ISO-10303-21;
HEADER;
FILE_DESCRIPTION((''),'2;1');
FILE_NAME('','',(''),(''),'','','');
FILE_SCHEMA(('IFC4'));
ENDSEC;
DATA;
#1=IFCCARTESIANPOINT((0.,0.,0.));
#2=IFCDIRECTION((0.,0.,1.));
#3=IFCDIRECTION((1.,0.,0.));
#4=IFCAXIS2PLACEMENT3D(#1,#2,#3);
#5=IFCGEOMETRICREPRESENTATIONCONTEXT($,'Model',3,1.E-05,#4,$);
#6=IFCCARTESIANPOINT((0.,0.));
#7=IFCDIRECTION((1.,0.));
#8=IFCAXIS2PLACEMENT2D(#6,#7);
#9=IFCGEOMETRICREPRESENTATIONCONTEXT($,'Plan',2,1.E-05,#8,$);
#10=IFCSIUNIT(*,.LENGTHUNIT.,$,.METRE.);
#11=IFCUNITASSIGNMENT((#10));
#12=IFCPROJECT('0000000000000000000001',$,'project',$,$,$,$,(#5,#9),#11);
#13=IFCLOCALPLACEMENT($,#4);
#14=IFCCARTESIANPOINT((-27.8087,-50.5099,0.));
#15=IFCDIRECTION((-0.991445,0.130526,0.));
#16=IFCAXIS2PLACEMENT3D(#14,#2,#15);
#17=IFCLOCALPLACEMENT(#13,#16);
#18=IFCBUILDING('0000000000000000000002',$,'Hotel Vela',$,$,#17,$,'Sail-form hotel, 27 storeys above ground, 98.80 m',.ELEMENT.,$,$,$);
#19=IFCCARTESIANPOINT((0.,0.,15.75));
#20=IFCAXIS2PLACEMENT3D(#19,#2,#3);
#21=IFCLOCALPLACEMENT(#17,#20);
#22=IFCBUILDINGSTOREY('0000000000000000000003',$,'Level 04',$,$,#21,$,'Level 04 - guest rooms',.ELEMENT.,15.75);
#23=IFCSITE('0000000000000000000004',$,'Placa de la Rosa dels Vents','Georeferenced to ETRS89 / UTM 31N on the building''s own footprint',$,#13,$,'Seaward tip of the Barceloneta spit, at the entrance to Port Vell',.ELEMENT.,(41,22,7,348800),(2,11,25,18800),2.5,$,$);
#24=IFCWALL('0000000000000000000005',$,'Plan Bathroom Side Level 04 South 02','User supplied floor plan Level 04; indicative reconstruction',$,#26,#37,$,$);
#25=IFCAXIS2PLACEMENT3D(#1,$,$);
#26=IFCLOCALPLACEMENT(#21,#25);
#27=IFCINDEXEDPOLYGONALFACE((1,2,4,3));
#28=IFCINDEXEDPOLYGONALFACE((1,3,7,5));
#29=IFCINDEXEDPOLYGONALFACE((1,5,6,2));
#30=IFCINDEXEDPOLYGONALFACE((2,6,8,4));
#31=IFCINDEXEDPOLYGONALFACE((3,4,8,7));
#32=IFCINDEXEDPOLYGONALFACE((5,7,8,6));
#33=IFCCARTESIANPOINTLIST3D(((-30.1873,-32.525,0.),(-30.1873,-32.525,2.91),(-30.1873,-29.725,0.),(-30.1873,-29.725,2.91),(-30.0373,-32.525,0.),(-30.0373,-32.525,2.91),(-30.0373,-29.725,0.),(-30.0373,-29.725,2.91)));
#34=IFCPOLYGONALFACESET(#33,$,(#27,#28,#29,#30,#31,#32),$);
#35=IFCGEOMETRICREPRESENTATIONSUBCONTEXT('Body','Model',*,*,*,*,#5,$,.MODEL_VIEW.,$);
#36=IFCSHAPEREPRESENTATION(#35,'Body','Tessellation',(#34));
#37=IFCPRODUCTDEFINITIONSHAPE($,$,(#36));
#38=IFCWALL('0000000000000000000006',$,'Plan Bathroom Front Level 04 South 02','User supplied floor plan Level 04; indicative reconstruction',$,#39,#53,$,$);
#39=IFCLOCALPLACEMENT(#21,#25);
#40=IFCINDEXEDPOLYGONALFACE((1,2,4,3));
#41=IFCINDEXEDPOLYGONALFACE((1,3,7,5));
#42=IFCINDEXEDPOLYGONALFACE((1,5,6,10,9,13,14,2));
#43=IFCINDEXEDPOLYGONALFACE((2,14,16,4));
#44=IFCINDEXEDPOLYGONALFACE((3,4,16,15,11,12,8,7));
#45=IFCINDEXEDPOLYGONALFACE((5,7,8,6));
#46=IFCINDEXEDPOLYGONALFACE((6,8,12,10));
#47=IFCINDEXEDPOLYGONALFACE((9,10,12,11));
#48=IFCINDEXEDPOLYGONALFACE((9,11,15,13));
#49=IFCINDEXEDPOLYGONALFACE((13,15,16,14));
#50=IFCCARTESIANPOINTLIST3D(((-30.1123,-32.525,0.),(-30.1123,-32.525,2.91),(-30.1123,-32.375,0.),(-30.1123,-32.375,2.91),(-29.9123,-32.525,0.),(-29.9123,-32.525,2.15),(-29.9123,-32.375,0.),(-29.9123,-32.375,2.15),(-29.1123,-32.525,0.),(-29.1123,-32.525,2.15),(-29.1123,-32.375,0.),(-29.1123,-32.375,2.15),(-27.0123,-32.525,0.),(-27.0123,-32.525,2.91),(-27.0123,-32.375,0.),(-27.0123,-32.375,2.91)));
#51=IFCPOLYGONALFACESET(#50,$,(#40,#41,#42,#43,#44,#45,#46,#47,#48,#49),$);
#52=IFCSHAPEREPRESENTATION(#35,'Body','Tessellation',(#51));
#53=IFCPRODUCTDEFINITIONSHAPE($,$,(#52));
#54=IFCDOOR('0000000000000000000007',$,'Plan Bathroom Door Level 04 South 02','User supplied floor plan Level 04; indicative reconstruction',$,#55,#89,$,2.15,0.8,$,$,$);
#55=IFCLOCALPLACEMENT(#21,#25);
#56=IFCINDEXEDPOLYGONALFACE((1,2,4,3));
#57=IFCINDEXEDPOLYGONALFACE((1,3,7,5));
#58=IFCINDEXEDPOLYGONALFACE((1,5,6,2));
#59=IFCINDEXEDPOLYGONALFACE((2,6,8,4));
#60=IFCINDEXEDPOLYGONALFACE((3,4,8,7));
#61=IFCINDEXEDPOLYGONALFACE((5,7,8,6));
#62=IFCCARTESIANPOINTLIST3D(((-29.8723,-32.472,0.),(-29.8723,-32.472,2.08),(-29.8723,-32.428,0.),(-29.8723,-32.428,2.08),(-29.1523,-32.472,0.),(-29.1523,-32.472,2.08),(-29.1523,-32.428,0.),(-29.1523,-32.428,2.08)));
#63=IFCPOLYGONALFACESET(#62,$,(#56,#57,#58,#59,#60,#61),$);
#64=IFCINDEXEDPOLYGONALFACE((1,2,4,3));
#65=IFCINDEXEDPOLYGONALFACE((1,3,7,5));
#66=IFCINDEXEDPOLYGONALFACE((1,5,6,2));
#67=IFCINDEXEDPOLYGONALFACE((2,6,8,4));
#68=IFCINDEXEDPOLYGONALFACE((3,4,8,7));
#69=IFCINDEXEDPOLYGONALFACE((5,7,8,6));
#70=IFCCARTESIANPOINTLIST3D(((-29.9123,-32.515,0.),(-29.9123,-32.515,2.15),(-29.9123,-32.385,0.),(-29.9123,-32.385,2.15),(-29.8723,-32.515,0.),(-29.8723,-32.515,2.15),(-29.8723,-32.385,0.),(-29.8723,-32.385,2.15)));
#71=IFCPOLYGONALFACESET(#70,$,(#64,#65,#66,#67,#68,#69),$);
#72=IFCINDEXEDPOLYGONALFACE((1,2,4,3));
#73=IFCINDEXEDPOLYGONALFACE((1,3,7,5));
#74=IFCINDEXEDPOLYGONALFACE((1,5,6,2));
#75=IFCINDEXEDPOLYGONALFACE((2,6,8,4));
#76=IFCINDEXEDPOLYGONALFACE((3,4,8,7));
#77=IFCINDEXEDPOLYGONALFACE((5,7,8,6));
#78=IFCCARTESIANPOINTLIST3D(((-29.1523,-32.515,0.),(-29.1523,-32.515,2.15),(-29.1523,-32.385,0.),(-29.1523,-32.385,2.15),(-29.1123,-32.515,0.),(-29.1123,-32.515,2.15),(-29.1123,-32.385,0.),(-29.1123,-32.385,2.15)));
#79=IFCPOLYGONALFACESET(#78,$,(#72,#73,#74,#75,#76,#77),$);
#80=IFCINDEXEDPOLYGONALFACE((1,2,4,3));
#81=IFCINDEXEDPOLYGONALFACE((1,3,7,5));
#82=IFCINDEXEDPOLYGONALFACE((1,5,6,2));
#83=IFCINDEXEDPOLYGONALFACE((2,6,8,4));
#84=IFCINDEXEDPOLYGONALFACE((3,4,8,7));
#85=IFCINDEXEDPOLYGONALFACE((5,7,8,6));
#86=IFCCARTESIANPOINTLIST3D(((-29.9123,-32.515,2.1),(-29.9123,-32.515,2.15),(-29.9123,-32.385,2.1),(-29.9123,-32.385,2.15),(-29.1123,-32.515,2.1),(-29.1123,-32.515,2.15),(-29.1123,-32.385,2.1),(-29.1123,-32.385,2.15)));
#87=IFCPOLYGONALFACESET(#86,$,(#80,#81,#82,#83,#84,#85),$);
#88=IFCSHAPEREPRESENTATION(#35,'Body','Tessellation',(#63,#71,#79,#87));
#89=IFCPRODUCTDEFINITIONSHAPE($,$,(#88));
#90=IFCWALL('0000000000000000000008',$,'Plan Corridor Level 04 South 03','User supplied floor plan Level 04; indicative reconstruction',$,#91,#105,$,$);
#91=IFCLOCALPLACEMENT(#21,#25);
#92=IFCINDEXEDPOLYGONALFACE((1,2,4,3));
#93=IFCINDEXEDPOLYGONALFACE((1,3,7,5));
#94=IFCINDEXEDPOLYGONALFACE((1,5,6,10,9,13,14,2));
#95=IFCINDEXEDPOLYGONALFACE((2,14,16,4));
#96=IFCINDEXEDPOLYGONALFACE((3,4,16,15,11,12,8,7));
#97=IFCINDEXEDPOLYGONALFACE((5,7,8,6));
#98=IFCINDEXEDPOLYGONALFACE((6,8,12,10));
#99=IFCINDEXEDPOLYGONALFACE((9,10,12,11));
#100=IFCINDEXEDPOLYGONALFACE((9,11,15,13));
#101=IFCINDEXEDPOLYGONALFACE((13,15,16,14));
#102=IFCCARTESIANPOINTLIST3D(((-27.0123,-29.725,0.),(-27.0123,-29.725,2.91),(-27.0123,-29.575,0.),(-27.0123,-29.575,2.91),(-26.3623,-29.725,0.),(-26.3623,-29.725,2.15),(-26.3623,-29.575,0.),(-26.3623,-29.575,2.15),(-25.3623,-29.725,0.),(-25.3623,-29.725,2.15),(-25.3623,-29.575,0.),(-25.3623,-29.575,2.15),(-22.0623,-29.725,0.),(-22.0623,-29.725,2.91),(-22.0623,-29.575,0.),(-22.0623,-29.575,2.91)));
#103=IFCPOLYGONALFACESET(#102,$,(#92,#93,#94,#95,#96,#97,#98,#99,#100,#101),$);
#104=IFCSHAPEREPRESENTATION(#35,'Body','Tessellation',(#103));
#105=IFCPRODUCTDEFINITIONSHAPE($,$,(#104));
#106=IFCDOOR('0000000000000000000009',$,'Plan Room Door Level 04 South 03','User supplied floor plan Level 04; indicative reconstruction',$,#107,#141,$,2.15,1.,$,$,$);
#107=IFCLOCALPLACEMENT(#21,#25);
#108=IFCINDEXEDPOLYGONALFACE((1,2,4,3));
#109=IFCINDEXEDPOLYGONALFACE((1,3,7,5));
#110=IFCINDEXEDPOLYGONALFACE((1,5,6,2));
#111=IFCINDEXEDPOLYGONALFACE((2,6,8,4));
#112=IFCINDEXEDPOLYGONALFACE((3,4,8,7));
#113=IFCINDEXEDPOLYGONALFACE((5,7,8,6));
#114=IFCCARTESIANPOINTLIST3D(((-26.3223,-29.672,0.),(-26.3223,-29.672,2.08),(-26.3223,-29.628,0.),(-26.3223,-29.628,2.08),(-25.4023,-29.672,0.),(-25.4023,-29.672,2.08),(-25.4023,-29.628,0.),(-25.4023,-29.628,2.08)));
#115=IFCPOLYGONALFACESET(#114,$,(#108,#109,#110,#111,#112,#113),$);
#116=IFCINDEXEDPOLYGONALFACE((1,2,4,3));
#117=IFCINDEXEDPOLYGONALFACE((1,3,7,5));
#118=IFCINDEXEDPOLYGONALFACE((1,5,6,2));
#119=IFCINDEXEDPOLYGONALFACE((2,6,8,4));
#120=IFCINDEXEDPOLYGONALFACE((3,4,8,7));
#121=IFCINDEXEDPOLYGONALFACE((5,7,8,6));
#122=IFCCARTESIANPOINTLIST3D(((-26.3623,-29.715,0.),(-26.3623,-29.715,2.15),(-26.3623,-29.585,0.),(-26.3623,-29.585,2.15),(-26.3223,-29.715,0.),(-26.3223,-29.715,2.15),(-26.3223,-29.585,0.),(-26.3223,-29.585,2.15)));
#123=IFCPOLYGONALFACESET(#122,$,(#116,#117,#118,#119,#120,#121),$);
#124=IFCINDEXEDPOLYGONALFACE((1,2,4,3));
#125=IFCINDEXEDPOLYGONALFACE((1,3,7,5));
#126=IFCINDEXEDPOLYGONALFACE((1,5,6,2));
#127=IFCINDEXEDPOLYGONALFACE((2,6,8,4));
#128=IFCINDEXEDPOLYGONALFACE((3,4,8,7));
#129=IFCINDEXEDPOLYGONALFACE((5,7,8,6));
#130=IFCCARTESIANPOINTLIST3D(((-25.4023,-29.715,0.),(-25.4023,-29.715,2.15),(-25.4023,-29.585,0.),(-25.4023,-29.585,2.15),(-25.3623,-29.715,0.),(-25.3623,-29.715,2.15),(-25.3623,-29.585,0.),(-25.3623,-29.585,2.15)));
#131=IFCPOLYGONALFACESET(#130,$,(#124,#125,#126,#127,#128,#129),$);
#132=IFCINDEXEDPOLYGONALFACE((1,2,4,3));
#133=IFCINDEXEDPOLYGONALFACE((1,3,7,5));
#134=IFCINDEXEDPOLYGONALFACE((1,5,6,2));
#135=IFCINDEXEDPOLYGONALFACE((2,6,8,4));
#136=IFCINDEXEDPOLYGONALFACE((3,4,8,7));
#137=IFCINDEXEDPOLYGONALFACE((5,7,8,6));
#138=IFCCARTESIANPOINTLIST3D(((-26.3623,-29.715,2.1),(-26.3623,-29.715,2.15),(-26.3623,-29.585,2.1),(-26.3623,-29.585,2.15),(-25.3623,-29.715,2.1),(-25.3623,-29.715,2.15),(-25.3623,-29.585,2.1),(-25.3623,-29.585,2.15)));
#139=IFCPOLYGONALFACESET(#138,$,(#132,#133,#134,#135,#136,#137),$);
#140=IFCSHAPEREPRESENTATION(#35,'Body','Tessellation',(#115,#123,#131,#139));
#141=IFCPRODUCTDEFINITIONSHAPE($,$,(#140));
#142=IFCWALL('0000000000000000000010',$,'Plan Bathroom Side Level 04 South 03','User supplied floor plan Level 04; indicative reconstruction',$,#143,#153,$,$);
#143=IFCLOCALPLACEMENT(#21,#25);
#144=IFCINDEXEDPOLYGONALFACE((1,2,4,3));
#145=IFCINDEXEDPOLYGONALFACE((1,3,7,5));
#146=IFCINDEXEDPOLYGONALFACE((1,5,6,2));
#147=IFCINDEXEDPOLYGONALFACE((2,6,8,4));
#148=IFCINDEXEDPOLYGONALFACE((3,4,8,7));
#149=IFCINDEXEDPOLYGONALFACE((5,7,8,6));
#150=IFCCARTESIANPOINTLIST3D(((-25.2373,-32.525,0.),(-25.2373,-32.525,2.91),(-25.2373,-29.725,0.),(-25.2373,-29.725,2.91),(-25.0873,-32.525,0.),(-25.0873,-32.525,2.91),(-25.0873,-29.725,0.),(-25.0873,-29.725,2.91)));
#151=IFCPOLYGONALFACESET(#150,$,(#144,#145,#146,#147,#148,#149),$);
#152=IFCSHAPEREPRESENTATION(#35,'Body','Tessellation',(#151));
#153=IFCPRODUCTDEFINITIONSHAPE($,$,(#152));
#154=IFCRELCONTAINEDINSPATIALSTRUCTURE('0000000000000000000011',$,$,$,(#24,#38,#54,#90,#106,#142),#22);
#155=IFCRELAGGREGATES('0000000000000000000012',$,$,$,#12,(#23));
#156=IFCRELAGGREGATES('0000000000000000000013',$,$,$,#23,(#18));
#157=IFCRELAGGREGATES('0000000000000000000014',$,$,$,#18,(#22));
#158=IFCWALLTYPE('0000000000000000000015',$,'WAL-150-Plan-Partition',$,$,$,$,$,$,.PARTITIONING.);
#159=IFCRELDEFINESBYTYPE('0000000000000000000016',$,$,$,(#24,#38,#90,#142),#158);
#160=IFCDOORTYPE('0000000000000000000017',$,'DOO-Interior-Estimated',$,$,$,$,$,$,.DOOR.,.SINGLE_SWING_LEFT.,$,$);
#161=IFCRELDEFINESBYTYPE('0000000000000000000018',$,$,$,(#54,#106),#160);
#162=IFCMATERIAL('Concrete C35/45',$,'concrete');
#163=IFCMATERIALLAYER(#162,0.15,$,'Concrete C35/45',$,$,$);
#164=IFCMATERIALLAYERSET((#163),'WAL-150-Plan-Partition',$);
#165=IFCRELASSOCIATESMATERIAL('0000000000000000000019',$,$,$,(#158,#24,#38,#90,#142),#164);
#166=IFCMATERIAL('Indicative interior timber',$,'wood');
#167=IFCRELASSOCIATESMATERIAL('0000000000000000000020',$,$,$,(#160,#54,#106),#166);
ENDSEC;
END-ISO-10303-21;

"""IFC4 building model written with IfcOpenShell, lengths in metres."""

from ifc_helpers import new_model, si_unit, frame, origin_with_axes, origin_2d_with_axis, place, context, subcontext, project, spatial, line, indexed_curve, outline, extrude, material, layer, layer_set, layer_usage, type_object, element, fill, save


model = new_model("IFC4")

# Units and contexts
model_context = context("Model", 3, precision=1e-05, world=origin_with_axes())
plan_context = context("Plan", 2, precision=1e-05, world=origin_2d_with_axis())
body_context = subcontext(model_context, "Body", "Model", "MODEL_VIEW")
ifc_project = project(units=[si_unit("LENGTHUNIT", "METRE")], contexts=[model_context, plan_context])

# Site, building, storey
site_placement = place(None, origin_with_axes())
site = spatial("IfcSite", under=ifc_project, at=site_placement, Name="Placa de la Rosa dels Vents", Description="Georeferenced to ETRS89 / UTM 31N on the building's own footprint", LongName="Seaward tip of the Barceloneta spit, at the entrance to Port Vell", CompositionType="ELEMENT", RefLatitude=(41, 22, 7, 348800), RefLongitude=(2, 11, 25, 18800), RefElevation=2.5)
building_placement = place(site_placement, frame((-27.8087, -50.5099, 0.0), z_axis=(0.0, 0.0, 1.0), x_axis=(-0.991445, 0.130526, 0.0)))
building = spatial("IfcBuilding", under=site, at=building_placement, Name="Hotel Vela", LongName="Sail-form hotel, 27 storeys above ground, 98.80 m", CompositionType="ELEMENT")
storey_placement = place(building_placement, frame((0.0, 0.0, 15.75), z_axis=(0.0, 0.0, 1.0), x_axis=(1.0, 0.0, 0.0)))
storey = spatial("IfcBuildingStorey", under=building, at=storey_placement, Name="Level 04", LongName="Level 04 - guest rooms", CompositionType="ELEMENT", Elevation=15.75)

# Wall
ifc_material_1 = material(Name="Concrete C35/45", Category="concrete")
ifc_layer = layer(ifc_material_1, 0.15, Name="Concrete C35/45")
ifc_layer_set = layer_set([ifc_layer], Name="WAL-150-Plan-Partition")
ifc_layer_usage_1 = layer_usage(ifc_layer_set, "AXIS2", "POSITIVE", 0.0)
wall_type = type_object("IfcWallType", Name="WAL-150-Plan-Partition", PredefinedType="PARTITIONING", material=ifc_layer_set)
wall_1_placement = place(storey_placement, frame((-30.1873, -32.525, 0.0), z_axis=(0.0, 0.0, 1.0), x_axis=(1.0, 0.0, 0.0)))
element("IfcWall", 1, at=wall_1_placement, inside=storey, type_object=wall_type, material=ifc_layer_usage_1, Name="Plan Bathroom Side Level 04 South 02", Description="User supplied floor plan Level 04; indicative reconstruction", context=body_context, shape_type="SweptSolid", body=[
    extrude(outline(indexed_curve([(0.0, 0.0), (0.15, 0.0), (0.15, 2.8), (0.0, 2.8)], segments=[line(1, 2, 3, 4, 1)])), origin_with_axes(), (0.0, 0.0, 1.0), 2.91),
])

# Walls, openings, doors
ifc_layer_usage_2 = layer_usage(ifc_layer_set, "AXIS2", "POSITIVE", 0.0)
wall_2_placement = place(storey_placement, frame((-30.1123, -32.525, 0.0), z_axis=(0.0, 0.0, 1.0), x_axis=(1.0, 0.0, 0.0)))
wall_2 = element("IfcWall", 2, at=wall_2_placement, inside=storey, type_object=wall_type, material=ifc_layer_usage_2, Name="Plan Bathroom Front Level 04 South 02", Description="User supplied floor plan Level 04; indicative reconstruction", context=body_context, shape_type="SweptSolid", body=[
    extrude(outline(indexed_curve([(0.0, 0.0), (3.1, 0.0), (3.1, 0.15), (0.0, 0.15)], segments=[line(1, 2, 3, 4, 1)])), origin_with_axes(), (0.0, 0.0, 1.0), 2.91),
])
opening_1_placement = place(wall_2_placement, frame((0.2, -0.085, 0.0), z_axis=(0.0, 0.0, 1.0), x_axis=(1.0, 0.0, 0.0)))
opening_1 = element("IfcOpeningElement", 3, at=opening_1_placement, cuts=wall_2, PredefinedType="OPENING", context=body_context, shape_type="SweptSolid", body=[
    extrude(outline(indexed_curve([(0.0, 0.0), (0.8, 0.0), (0.8, 0.32), (0.0, 0.32)], segments=[line(1, 2, 3, 4, 1)])), origin_with_axes(), (0.0, 0.0, 1.0), 2.15),
])
ifc_material_2 = material(Name="Indicative interior timber", Category="wood")
door_type = type_object("IfcDoorType", Name="DOO-Interior-Estimated", OperationType="SINGLE_SWING_LEFT", PredefinedType="DOOR", material=ifc_material_2)
door_1_placement = place(storey_placement, frame((0.0, 0.0, -15.75), z_axis=(0.0, 0.0, 1.0), x_axis=(1.0, 0.0, 0.0)))
door_1 = element("IfcDoor", 4, at=door_1_placement, inside=storey, type_object=door_type, material=ifc_material_2, Name="Plan Bathroom Door Level 04 South 02", Description="User supplied floor plan Level 04; indicative reconstruction", OverallHeight=2.15, OverallWidth=0.8, context=body_context, shape_type="SweptSolid", body=[
    extrude(outline(indexed_curve([(0.0, 0.0), (0.72, 0.0), (0.72, 0.044), (0.0, 0.044)], segments=[line(1, 2, 3, 4, 1)])), frame((-29.8723, -32.472, 15.75), z_axis=(0.0, 0.0, 1.0), x_axis=(1.0, 0.0, 0.0)), (0.0, 0.0, 1.0), 2.08),
    extrude(outline(indexed_curve([(0.0, 0.0), (0.04, 0.0), (0.04, 0.13), (0.0, 0.13)], segments=[line(1, 2, 3, 4, 1)])), frame((-29.9123, -32.515, 15.75), z_axis=(0.0, 0.0, 1.0), x_axis=(1.0, 0.0, 0.0)), (0.0, 0.0, 1.0), 2.15),
    extrude(outline(indexed_curve([(0.0, 0.0), (0.04, 0.0), (0.04, 0.13), (0.0, 0.13)], segments=[line(1, 2, 3, 4, 1)])), frame((-29.1523, -32.515, 15.75), z_axis=(0.0, 0.0, 1.0), x_axis=(1.0, 0.0, 0.0)), (0.0, 0.0, 1.0), 2.15),
    extrude(outline(indexed_curve([(0.0, 0.0), (0.8, 0.0), (0.8, 0.13), (0.0, 0.13)], segments=[line(1, 2, 3, 4, 1)])), frame((-29.9123, -32.515, 17.85), z_axis=(0.0, 0.0, 1.0), x_axis=(1.0, 0.0, 0.0)), (0.0, 0.0, 1.0), 0.05),
])
fill(opening_1, door_1)
ifc_layer_usage_3 = layer_usage(ifc_layer_set, "AXIS2", "POSITIVE", 0.0)
wall_3_placement = place(storey_placement, frame((-27.0123, -29.725, 0.0), z_axis=(0.0, 0.0, 1.0), x_axis=(1.0, 0.0, 0.0)))
wall_3 = element("IfcWall", 5, at=wall_3_placement, inside=storey, type_object=wall_type, material=ifc_layer_usage_3, Name="Plan Corridor Level 04 South 03", Description="User supplied floor plan Level 04; indicative reconstruction", context=body_context, shape_type="SweptSolid", body=[
    extrude(outline(indexed_curve([(0.0, 0.0), (4.95, 0.0), (4.95, 0.15), (0.0, 0.15)], segments=[line(1, 2, 3, 4, 1)])), origin_with_axes(), (0.0, 0.0, 1.0), 2.91),
])
opening_2_placement = place(wall_3_placement, frame((0.65, -0.085, 0.0), z_axis=(0.0, 0.0, 1.0), x_axis=(1.0, 0.0, 0.0)))
opening_2 = element("IfcOpeningElement", 6, at=opening_2_placement, cuts=wall_3, PredefinedType="OPENING", context=body_context, shape_type="SweptSolid", body=[
    extrude(outline(indexed_curve([(0.0, 0.0), (1.0, 0.0), (1.0, 0.32), (0.0, 0.32)], segments=[line(1, 2, 3, 4, 1)])), origin_with_axes(), (0.0, 0.0, 1.0), 2.15),
])
door_2_placement = place(storey_placement, frame((0.0, 0.0, -15.75), z_axis=(0.0, 0.0, 1.0), x_axis=(1.0, 0.0, 0.0)))
door_2 = element("IfcDoor", 7, at=door_2_placement, inside=storey, type_object=door_type, material=ifc_material_2, Name="Plan Room Door Level 04 South 03", Description="User supplied floor plan Level 04; indicative reconstruction", OverallHeight=2.15, OverallWidth=1.0, context=body_context, shape_type="SweptSolid", body=[
    extrude(outline(indexed_curve([(0.0, 0.0), (0.92, 0.0), (0.92, 0.044), (0.0, 0.044)], segments=[line(1, 2, 3, 4, 1)])), frame((-26.3223, -29.672, 15.75), z_axis=(0.0, 0.0, 1.0), x_axis=(1.0, 0.0, 0.0)), (0.0, 0.0, 1.0), 2.08),
    extrude(outline(indexed_curve([(0.0, 0.0), (0.04, 0.0), (0.04, 0.13), (0.0, 0.13)], segments=[line(1, 2, 3, 4, 1)])), frame((-26.3623, -29.715, 15.75), z_axis=(0.0, 0.0, 1.0), x_axis=(1.0, 0.0, 0.0)), (0.0, 0.0, 1.0), 2.15),
    extrude(outline(indexed_curve([(0.0, 0.0), (0.04, 0.0), (0.04, 0.13), (0.0, 0.13)], segments=[line(1, 2, 3, 4, 1)])), frame((-25.4023, -29.715, 15.75), z_axis=(0.0, 0.0, 1.0), x_axis=(1.0, 0.0, 0.0)), (0.0, 0.0, 1.0), 2.15),
    extrude(outline(indexed_curve([(0.0, 0.0), (1.0, 0.0), (1.0, 0.13), (0.0, 0.13)], segments=[line(1, 2, 3, 4, 1)])), frame((-26.3623, -29.715, 17.85), z_axis=(0.0, 0.0, 1.0), x_axis=(1.0, 0.0, 0.0)), (0.0, 0.0, 1.0), 0.05),
])
fill(opening_2, door_2)

# Wall
ifc_layer_usage_4 = layer_usage(ifc_layer_set, "AXIS2", "POSITIVE", 0.0)
wall_4_placement = place(storey_placement, frame((-25.2373, -32.525, 0.0), z_axis=(0.0, 0.0, 1.0), x_axis=(1.0, 0.0, 0.0)))
element("IfcWall", 8, at=wall_4_placement, inside=storey, type_object=wall_type, material=ifc_layer_usage_4, Name="Plan Bathroom Side Level 04 South 03", Description="User supplied floor plan Level 04; indicative reconstruction", context=body_context, shape_type="SweptSolid", body=[
    extrude(outline(indexed_curve([(0.0, 0.0), (0.15, 0.0), (0.15, 2.8), (0.0, 2.8)], segments=[line(1, 2, 3, 4, 1)])), origin_with_axes(), (0.0, 0.0, 1.0), 2.91),
])

save(model, "model.ifc")
